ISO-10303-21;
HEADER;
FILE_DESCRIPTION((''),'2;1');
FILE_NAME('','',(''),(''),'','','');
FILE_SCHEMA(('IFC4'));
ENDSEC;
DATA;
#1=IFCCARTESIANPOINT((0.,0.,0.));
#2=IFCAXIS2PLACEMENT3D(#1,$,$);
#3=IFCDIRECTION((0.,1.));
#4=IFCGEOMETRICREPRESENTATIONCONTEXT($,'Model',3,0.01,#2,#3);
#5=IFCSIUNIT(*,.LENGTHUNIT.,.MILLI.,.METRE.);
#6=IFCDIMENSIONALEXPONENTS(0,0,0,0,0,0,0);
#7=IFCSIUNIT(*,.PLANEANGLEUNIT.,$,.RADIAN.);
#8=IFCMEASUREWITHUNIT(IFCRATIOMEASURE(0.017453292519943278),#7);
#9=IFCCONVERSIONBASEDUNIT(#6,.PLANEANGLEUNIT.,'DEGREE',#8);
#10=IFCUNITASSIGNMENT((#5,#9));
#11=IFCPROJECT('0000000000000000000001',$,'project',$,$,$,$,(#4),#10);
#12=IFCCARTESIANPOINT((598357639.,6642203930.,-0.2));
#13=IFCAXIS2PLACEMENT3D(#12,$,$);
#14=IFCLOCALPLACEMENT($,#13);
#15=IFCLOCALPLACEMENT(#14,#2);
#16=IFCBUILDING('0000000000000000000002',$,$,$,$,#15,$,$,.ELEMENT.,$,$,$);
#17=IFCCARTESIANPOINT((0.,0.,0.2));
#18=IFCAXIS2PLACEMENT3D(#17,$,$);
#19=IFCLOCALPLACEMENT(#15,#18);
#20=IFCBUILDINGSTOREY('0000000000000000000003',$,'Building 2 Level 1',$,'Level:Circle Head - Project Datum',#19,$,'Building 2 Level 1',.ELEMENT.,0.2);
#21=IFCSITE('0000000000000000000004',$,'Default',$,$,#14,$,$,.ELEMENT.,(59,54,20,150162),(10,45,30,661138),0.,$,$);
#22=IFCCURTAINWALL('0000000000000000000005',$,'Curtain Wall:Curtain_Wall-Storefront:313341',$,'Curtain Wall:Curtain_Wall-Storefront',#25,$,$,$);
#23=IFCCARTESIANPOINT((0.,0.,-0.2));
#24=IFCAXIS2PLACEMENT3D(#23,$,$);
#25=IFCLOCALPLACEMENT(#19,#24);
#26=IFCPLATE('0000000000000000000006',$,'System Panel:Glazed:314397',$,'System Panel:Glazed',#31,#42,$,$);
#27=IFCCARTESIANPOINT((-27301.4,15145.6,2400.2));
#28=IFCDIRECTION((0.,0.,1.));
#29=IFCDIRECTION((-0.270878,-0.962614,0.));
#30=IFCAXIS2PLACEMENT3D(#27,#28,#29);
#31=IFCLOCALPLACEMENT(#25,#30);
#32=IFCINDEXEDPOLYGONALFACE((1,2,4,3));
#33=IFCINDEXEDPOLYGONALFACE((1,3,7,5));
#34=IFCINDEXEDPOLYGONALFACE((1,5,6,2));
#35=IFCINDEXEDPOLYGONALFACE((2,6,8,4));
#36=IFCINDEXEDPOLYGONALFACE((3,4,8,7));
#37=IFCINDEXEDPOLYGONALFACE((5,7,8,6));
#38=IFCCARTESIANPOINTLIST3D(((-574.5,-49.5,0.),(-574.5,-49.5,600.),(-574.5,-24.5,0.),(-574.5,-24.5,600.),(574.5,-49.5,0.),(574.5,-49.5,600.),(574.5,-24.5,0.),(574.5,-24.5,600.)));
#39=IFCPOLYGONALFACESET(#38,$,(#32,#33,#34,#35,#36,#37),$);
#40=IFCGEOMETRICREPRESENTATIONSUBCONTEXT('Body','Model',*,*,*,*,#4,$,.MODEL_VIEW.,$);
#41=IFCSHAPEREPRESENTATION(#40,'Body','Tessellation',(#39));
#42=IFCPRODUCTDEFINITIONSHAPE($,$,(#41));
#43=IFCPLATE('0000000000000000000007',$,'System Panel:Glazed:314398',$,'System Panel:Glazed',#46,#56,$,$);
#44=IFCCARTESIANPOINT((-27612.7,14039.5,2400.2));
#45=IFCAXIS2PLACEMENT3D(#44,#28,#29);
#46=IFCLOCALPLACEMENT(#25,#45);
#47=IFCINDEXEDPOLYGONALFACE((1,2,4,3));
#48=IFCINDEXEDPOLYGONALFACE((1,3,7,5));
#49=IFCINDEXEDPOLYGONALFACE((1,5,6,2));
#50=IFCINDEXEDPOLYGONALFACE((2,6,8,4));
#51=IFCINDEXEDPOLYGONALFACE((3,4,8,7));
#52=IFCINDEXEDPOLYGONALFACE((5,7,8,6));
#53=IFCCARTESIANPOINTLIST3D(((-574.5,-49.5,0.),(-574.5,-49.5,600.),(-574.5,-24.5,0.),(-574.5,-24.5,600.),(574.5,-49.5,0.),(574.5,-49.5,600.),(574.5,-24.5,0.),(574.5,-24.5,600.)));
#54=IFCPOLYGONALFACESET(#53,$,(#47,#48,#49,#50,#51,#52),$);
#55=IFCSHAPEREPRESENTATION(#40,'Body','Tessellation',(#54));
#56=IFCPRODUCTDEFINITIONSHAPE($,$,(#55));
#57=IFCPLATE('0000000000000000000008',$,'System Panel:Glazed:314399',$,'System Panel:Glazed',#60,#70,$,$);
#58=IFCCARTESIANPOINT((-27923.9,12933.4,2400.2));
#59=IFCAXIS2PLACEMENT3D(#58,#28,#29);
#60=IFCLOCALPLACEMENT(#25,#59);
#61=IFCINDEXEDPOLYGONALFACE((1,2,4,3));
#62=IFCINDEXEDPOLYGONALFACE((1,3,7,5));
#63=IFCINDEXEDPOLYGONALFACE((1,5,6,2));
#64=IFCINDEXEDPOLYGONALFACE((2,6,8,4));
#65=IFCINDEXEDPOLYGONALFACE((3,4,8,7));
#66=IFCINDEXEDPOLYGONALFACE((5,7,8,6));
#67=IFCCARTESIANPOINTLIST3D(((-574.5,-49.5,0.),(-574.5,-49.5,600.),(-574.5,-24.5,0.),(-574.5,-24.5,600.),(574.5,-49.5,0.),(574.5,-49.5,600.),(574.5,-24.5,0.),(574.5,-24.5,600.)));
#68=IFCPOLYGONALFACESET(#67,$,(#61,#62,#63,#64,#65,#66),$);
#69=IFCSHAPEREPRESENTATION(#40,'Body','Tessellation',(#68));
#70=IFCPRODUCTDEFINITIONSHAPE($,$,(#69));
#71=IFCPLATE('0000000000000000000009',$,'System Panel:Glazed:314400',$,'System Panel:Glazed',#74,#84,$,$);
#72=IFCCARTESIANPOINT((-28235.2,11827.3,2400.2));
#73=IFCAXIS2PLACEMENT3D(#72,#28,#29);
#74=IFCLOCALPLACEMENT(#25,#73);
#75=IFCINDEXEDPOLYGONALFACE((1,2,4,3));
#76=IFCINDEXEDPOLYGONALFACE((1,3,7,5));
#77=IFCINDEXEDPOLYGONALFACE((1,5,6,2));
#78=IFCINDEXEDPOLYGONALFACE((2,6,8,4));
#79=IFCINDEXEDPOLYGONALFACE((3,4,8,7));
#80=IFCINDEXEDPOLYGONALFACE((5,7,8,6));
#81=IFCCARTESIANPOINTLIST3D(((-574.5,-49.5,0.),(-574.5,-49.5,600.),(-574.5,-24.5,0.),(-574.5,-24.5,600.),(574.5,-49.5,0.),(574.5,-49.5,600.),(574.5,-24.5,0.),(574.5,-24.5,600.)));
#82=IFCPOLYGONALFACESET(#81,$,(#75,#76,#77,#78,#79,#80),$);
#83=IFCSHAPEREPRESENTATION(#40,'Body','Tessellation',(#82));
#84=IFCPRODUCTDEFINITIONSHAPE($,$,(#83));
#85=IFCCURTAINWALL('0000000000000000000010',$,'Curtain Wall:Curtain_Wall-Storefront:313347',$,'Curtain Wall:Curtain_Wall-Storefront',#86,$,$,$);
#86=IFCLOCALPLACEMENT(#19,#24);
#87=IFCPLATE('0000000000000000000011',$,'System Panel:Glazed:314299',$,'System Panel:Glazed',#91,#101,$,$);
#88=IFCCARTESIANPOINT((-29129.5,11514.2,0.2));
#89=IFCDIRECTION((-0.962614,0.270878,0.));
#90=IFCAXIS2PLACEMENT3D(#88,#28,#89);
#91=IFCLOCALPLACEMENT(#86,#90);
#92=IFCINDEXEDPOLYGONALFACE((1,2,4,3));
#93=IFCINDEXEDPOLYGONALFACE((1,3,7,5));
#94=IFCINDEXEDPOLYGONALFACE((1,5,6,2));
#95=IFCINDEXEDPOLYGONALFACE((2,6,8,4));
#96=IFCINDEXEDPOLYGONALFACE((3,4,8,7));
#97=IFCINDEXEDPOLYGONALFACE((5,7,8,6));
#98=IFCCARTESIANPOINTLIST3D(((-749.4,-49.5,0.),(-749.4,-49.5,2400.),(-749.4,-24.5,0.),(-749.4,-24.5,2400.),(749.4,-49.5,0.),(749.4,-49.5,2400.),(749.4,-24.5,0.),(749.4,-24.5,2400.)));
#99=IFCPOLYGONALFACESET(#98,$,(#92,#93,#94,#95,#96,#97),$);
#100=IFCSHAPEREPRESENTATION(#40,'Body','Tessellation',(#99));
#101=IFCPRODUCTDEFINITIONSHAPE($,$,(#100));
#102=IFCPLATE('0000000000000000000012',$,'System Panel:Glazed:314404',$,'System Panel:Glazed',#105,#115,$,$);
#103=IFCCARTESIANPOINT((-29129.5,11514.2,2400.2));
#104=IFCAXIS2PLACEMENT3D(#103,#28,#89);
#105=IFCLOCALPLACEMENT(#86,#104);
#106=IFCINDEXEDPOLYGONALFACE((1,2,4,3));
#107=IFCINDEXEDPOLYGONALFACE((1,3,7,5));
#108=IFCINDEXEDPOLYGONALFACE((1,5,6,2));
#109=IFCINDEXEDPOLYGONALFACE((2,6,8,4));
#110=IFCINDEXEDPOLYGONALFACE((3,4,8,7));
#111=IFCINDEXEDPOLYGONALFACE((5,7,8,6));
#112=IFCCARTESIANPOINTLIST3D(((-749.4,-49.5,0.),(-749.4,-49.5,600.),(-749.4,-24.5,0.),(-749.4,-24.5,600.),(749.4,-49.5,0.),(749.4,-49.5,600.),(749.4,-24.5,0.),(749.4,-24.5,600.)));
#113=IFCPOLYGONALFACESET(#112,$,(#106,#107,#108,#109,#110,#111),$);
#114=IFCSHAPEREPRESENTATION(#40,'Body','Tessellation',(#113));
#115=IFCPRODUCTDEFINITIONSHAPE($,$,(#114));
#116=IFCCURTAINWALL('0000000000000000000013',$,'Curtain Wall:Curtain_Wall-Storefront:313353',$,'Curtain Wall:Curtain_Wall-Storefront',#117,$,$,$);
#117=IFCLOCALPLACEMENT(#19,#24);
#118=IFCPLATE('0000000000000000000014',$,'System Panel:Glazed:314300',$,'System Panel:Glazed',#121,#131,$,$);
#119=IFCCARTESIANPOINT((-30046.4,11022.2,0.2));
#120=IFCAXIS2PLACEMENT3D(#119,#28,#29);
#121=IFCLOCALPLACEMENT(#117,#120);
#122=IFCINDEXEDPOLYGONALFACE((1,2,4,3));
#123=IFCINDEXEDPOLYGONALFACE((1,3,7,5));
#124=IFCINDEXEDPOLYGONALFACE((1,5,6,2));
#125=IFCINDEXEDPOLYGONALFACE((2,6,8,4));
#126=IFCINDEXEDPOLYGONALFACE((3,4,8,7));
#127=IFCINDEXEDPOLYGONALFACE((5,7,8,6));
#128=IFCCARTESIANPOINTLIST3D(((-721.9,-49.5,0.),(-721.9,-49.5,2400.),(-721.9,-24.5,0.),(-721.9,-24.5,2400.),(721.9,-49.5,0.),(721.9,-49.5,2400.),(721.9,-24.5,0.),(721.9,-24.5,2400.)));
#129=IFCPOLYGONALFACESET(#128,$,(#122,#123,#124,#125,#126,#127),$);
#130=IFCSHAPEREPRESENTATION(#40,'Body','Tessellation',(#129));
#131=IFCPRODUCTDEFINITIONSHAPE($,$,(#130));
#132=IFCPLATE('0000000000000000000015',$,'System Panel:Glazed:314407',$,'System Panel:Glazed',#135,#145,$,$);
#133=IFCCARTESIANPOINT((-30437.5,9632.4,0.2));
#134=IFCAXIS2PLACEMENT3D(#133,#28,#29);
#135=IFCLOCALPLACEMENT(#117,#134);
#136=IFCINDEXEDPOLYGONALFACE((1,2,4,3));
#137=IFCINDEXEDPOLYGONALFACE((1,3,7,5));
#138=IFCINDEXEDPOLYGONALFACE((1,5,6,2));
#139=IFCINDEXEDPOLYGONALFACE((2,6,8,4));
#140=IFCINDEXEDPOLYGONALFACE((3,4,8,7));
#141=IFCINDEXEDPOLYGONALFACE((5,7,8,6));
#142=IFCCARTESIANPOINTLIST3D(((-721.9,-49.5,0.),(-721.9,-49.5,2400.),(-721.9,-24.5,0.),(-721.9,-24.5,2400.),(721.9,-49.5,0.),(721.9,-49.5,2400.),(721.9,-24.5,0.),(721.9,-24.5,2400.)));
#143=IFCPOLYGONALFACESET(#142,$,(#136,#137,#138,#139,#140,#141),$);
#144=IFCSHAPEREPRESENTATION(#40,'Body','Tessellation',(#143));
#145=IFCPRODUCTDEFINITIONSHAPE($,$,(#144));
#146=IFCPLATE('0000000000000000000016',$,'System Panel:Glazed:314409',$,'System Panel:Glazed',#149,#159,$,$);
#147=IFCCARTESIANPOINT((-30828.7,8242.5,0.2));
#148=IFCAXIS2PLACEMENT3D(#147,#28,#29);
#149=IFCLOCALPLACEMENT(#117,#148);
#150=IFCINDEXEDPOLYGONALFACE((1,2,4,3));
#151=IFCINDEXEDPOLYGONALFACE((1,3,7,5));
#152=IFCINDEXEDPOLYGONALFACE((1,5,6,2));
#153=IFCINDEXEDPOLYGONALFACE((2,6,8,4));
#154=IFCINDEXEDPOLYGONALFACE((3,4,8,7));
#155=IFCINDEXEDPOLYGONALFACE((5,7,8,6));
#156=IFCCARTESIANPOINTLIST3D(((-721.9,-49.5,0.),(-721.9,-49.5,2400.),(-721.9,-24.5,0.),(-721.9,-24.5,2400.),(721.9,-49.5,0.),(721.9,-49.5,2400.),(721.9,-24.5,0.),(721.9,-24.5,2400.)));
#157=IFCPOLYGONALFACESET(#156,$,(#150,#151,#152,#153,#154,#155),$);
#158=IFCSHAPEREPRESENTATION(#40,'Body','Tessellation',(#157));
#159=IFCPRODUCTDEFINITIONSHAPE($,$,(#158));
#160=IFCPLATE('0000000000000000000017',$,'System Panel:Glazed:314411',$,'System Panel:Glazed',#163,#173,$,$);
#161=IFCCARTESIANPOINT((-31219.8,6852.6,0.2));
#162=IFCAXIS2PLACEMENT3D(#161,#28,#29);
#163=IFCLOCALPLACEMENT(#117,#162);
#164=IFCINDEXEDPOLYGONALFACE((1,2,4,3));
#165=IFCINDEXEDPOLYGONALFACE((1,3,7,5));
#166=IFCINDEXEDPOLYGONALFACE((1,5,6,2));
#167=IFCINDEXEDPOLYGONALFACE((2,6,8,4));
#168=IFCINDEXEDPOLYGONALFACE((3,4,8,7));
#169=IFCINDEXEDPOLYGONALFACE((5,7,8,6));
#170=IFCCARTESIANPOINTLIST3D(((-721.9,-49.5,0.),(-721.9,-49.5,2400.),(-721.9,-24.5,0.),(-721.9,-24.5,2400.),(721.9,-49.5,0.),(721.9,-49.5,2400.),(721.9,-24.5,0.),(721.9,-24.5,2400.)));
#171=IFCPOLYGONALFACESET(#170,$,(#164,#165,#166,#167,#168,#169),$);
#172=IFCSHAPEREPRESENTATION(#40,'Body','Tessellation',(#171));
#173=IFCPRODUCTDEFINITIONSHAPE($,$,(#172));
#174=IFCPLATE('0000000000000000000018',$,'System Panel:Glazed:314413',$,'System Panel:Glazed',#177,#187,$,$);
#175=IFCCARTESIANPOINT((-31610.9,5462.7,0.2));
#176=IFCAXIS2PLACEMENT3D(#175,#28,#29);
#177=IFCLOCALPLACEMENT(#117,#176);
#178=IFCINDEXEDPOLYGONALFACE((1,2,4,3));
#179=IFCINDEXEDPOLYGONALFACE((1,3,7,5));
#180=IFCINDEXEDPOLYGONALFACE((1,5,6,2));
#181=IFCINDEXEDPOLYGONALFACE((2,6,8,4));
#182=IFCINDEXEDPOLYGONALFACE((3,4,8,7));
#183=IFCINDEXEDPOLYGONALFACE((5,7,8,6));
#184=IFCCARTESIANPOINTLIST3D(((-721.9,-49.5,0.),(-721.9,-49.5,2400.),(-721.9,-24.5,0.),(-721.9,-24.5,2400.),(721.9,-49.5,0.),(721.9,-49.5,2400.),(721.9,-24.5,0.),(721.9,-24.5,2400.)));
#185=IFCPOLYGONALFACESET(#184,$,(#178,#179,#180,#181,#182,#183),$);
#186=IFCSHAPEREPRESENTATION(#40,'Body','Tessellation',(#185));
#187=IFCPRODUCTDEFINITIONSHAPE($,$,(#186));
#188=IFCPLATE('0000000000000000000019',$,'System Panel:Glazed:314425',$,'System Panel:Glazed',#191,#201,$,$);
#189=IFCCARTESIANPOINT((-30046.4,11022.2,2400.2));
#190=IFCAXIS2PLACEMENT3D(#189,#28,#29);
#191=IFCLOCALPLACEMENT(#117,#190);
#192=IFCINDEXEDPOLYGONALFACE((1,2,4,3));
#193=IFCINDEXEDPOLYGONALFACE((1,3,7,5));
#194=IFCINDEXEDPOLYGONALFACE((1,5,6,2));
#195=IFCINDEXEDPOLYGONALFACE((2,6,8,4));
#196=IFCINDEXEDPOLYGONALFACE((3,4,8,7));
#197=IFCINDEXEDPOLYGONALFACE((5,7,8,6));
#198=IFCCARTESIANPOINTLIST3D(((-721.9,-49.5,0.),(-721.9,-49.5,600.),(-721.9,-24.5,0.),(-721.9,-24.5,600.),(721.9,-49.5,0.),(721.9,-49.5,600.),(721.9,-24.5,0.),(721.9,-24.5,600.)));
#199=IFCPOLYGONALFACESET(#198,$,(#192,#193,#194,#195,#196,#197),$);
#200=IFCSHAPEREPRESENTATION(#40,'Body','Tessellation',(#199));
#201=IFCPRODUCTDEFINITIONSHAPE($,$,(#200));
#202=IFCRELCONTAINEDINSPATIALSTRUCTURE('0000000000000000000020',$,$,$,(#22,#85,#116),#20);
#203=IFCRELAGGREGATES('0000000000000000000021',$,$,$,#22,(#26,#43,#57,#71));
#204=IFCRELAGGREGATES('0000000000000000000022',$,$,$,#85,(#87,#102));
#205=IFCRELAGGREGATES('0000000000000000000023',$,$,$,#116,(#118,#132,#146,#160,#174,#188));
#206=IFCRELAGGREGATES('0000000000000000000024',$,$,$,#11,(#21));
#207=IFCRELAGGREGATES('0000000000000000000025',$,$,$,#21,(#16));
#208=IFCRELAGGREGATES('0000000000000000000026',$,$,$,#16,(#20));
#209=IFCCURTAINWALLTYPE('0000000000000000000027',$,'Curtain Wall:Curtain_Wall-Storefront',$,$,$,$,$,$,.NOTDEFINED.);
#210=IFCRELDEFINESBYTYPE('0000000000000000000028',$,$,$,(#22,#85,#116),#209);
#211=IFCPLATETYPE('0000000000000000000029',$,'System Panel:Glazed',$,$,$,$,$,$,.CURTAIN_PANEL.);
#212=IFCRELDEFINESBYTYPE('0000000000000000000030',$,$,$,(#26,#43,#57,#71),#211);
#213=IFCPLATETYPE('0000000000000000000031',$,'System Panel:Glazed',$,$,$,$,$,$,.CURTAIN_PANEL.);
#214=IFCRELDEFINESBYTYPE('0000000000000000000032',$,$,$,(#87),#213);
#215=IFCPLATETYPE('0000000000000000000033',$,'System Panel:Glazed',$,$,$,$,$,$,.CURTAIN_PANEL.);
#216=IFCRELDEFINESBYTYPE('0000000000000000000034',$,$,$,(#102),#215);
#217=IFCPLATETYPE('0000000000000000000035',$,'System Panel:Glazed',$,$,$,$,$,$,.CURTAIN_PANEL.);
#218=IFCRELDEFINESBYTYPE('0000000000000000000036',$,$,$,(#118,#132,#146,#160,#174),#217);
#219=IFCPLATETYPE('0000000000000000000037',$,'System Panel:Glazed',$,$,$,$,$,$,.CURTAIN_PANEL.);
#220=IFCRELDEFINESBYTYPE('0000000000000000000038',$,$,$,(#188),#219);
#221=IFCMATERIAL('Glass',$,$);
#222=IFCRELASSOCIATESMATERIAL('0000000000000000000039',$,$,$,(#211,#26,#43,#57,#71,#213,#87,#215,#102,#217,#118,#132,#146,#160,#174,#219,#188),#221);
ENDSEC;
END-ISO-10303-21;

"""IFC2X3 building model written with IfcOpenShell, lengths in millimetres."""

from ifc_helpers import new_model, entity, si_unit, converted_unit, direction, frame, frame_2d, origin, place, context, subcontext, project, spatial, rectangle, extrude, source, transform, mapped, material, type_object, type_shapes, element, aggregate, save


model = new_model("IFC2X3")

# Units and contexts
model_context = context("Model", 3, precision=0.01, world=origin(), true_north=direction((0.0, 1.0)))
body_context = subcontext(model_context, "Body", "Model", "MODEL_VIEW")
ifc_project = project(units=[si_unit("LENGTHUNIT", "METRE", prefix="MILLI"), converted_unit("PLANEANGLEUNIT", "DEGREE", entity("IfcRatioMeasure", 0.017453292519943278), si_unit("PLANEANGLEUNIT", "RADIAN"), dimensions=[0, 0, 0, 0, 0, 0, 0])], contexts=[model_context])

# Site, building, storey
site_placement = place(None, frame((598357639.0, 6642203930.0, -0.2)))
site = spatial("IfcSite", under=ifc_project, at=site_placement, Name="Default", CompositionType="ELEMENT", RefLatitude=(59, 54, 20, 150162), RefLongitude=(10, 45, 30, 661138), RefElevation=0.0)
building_placement = place(site_placement, origin())
building = spatial("IfcBuilding", under=site, at=building_placement, CompositionType="ELEMENT")
storey_placement = place(building_placement, frame((0.0, 0.0, 0.2)))
storey = spatial("IfcBuildingStorey", under=building, at=storey_placement, Name="Building 2 Level 1", ObjectType="Level:Circle Head - Project Datum", LongName="Building 2 Level 1", CompositionType="ELEMENT", Elevation=0.2)

# Curtain walls, plates
curtain_wall_type = type_object("IfcCurtainWallType", Name="Curtain Wall:Curtain_Wall-Storefront", PredefinedType="NOTDEFINED")
ifc_material = material(Name="Glass")
curtain_wall_1_placement = place(storey_placement, frame((0.0, 0.0, -0.2)))
curtain_wall_1 = element("IfcCurtainWall", 1, at=curtain_wall_1_placement, inside=storey, type_object=curtain_wall_type, Name="Curtain Wall:Curtain_Wall-Storefront:313341", ObjectType="Curtain Wall:Curtain_Wall-Storefront")
plate_type_1 = type_object("IfcPlateType", Name="System Panel:Glazed", PredefinedType="CURTAIN_PANEL", material=ifc_material)
shared_shape_1 = source(origin(), body_context, "Body", "SweptSolid", [
    extrude(rectangle(XDim=25.0, YDim=1149.1, at=frame_2d((0.0, 0.0), x_axis=(1.0, 0.0))), frame((0.0, -37.0, 0.0), z_axis=(0.0, 0.0, 1.0), x_axis=(0.0, 1.0, 0.0)), (0.0, 0.0, 1.0), 600.0),
])
type_shapes(plate_type_1, [shared_shape_1])
plate_1_placement = place(curtain_wall_1_placement, frame((-27301.4, 15145.6, 2400.2), z_axis=(0.0, 0.0, 1.0), x_axis=(-0.270878, -0.962614, 0.0)))
plate_1 = element("IfcPlate", 2, at=plate_1_placement, type_object=plate_type_1, material=ifc_material, Name="System Panel:Glazed:314397", ObjectType="System Panel:Glazed", context=body_context, shape_type="MappedRepresentation", body=[
    mapped(shared_shape_1, transform((0.0, 0.0, 0.0), scale=1.0)),
])
plate_2_placement = place(curtain_wall_1_placement, frame((-27612.7, 14039.5, 2400.2), z_axis=(0.0, 0.0, 1.0), x_axis=(-0.270878, -0.962614, 0.0)))
plate_2 = element("IfcPlate", 3, at=plate_2_placement, type_object=plate_type_1, material=ifc_material, Name="System Panel:Glazed:314398", ObjectType="System Panel:Glazed", context=body_context, shape_type="MappedRepresentation", body=[
    mapped(shared_shape_1, transform((0.0, 0.0, 0.0), scale=1.0)),
])
plate_3_placement = place(curtain_wall_1_placement, frame((-27923.9, 12933.4, 2400.2), z_axis=(0.0, 0.0, 1.0), x_axis=(-0.270878, -0.962614, 0.0)))
plate_3 = element("IfcPlate", 4, at=plate_3_placement, type_object=plate_type_1, material=ifc_material, Name="System Panel:Glazed:314399", ObjectType="System Panel:Glazed", context=body_context, shape_type="MappedRepresentation", body=[
    mapped(shared_shape_1, transform((0.0, 0.0, 0.0), scale=1.0)),
])
plate_4_placement = place(curtain_wall_1_placement, frame((-28235.2, 11827.3, 2400.2), z_axis=(0.0, 0.0, 1.0), x_axis=(-0.270878, -0.962614, 0.0)))
plate_4 = element("IfcPlate", 5, at=plate_4_placement, type_object=plate_type_1, material=ifc_material, Name="System Panel:Glazed:314400", ObjectType="System Panel:Glazed", context=body_context, shape_type="MappedRepresentation", body=[
    mapped(shared_shape_1, transform((0.0, 0.0, 0.0), scale=1.0)),
])
aggregate(curtain_wall_1, [plate_1, plate_2, plate_3, plate_4])
curtain_wall_2_placement = place(storey_placement, frame((0.0, 0.0, -0.2)))
curtain_wall_2 = element("IfcCurtainWall", 6, at=curtain_wall_2_placement, inside=storey, type_object=curtain_wall_type, Name="Curtain Wall:Curtain_Wall-Storefront:313347", ObjectType="Curtain Wall:Curtain_Wall-Storefront")
plate_type_2 = type_object("IfcPlateType", Name="System Panel:Glazed", PredefinedType="CURTAIN_PANEL", material=ifc_material)
shared_shape_2 = source(origin(), body_context, "Body", "SweptSolid", [
    extrude(rectangle(XDim=25.0, YDim=1498.7, at=frame_2d((0.0, 0.0), x_axis=(1.0, 0.0))), frame((0.0, -37.0, 0.0), z_axis=(0.0, 0.0, 1.0), x_axis=(0.0, 1.0, 0.0)), (0.0, 0.0, 1.0), 2400.0),
])
type_shapes(plate_type_2, [shared_shape_2])
plate_5_placement = place(curtain_wall_2_placement, frame((-29129.5, 11514.2, 0.2), z_axis=(0.0, 0.0, 1.0), x_axis=(-0.962614, 0.270878, 0.0)))
plate_5 = element("IfcPlate", 7, at=plate_5_placement, type_object=plate_type_2, material=ifc_material, Name="System Panel:Glazed:314299", ObjectType="System Panel:Glazed", context=body_context, shape_type="MappedRepresentation", body=[
    mapped(shared_shape_2, transform((0.0, 0.0, 0.0), scale=1.0)),
])
plate_type_3 = type_object("IfcPlateType", Name="System Panel:Glazed", PredefinedType="CURTAIN_PANEL", material=ifc_material)
shared_shape_3 = source(origin(), body_context, "Body", "SweptSolid", [
    extrude(rectangle(XDim=25.0, YDim=1498.7, at=frame_2d((0.0, 0.0), x_axis=(1.0, 0.0))), frame((0.0, -37.0, 0.0), z_axis=(0.0, 0.0, 1.0), x_axis=(0.0, 1.0, 0.0)), (0.0, 0.0, 1.0), 600.0),
])
type_shapes(plate_type_3, [shared_shape_3])
plate_6_placement = place(curtain_wall_2_placement, frame((-29129.5, 11514.2, 2400.2), z_axis=(0.0, 0.0, 1.0), x_axis=(-0.962614, 0.270878, 0.0)))
plate_6 = element("IfcPlate", 8, at=plate_6_placement, type_object=plate_type_3, material=ifc_material, Name="System Panel:Glazed:314404", ObjectType="System Panel:Glazed", context=body_context, shape_type="MappedRepresentation", body=[
    mapped(shared_shape_3, transform((0.0, 0.0, 0.0), scale=1.0)),
])
aggregate(curtain_wall_2, [plate_5, plate_6])
curtain_wall_3_placement = place(storey_placement, frame((0.0, 0.0, -0.2)))
curtain_wall_3 = element("IfcCurtainWall", 9, at=curtain_wall_3_placement, inside=storey, type_object=curtain_wall_type, Name="Curtain Wall:Curtain_Wall-Storefront:313353", ObjectType="Curtain Wall:Curtain_Wall-Storefront")
plate_type_4 = type_object("IfcPlateType", Name="System Panel:Glazed", PredefinedType="CURTAIN_PANEL", material=ifc_material)
shared_shape_4 = source(origin(), body_context, "Body", "SweptSolid", [
    extrude(rectangle(XDim=25.0, YDim=1443.9, at=frame_2d((0.0, 0.0), x_axis=(1.0, 0.0))), frame((0.0, -37.0, 0.0), z_axis=(0.0, 0.0, 1.0), x_axis=(0.0, 1.0, 0.0)), (0.0, 0.0, 1.0), 2400.0),
])
type_shapes(plate_type_4, [shared_shape_4])
plate_7_placement = place(curtain_wall_3_placement, frame((-30046.4, 11022.2, 0.2), z_axis=(0.0, 0.0, 1.0), x_axis=(-0.270878, -0.962614, 0.0)))
plate_7 = element("IfcPlate", 10, at=plate_7_placement, type_object=plate_type_4, material=ifc_material, Name="System Panel:Glazed:314300", ObjectType="System Panel:Glazed", context=body_context, shape_type="MappedRepresentation", body=[
    mapped(shared_shape_4, transform((0.0, 0.0, 0.0), scale=1.0)),
])
plate_8_placement = place(curtain_wall_3_placement, frame((-30437.5, 9632.4, 0.2), z_axis=(0.0, 0.0, 1.0), x_axis=(-0.270878, -0.962614, 0.0)))
plate_8 = element("IfcPlate", 11, at=plate_8_placement, type_object=plate_type_4, material=ifc_material, Name="System Panel:Glazed:314407", ObjectType="System Panel:Glazed", context=body_context, shape_type="MappedRepresentation", body=[
    mapped(shared_shape_4, transform((0.0, 0.0, 0.0), scale=1.0)),
])
plate_9_placement = place(curtain_wall_3_placement, frame((-30828.7, 8242.5, 0.2), z_axis=(0.0, 0.0, 1.0), x_axis=(-0.270878, -0.962614, 0.0)))
plate_9 = element("IfcPlate", 12, at=plate_9_placement, type_object=plate_type_4, material=ifc_material, Name="System Panel:Glazed:314409", ObjectType="System Panel:Glazed", context=body_context, shape_type="MappedRepresentation", body=[
    mapped(shared_shape_4, transform((0.0, 0.0, 0.0), scale=1.0)),
])
plate_10_placement = place(curtain_wall_3_placement, frame((-31219.8, 6852.6, 0.2), z_axis=(0.0, 0.0, 1.0), x_axis=(-0.270878, -0.962614, 0.0)))
plate_10 = element("IfcPlate", 13, at=plate_10_placement, type_object=plate_type_4, material=ifc_material, Name="System Panel:Glazed:314411", ObjectType="System Panel:Glazed", context=body_context, shape_type="MappedRepresentation", body=[
    mapped(shared_shape_4, transform((0.0, 0.0, 0.0), scale=1.0)),
])
plate_11_placement = place(curtain_wall_3_placement, frame((-31610.9, 5462.7, 0.2), z_axis=(0.0, 0.0, 1.0), x_axis=(-0.270878, -0.962614, 0.0)))
plate_11 = element("IfcPlate", 14, at=plate_11_placement, type_object=plate_type_4, material=ifc_material, Name="System Panel:Glazed:314413", ObjectType="System Panel:Glazed", context=body_context, shape_type="MappedRepresentation", body=[
    mapped(shared_shape_4, transform((0.0, 0.0, 0.0), scale=1.0)),
])
plate_type_5 = type_object("IfcPlateType", Name="System Panel:Glazed", PredefinedType="CURTAIN_PANEL", material=ifc_material)
shared_shape_5 = source(origin(), body_context, "Body", "SweptSolid", [
    extrude(rectangle(XDim=25.0, YDim=1443.9, at=frame_2d((0.0, 0.0), x_axis=(1.0, 0.0))), frame((0.0, -37.0, 0.0), z_axis=(0.0, 0.0, 1.0), x_axis=(0.0, 1.0, 0.0)), (0.0, 0.0, 1.0), 600.0),
])
type_shapes(plate_type_5, [shared_shape_5])
plate_12_placement = place(curtain_wall_3_placement, frame((-30046.4, 11022.2, 2400.2), z_axis=(0.0, 0.0, 1.0), x_axis=(-0.270878, -0.962614, 0.0)))
plate_12 = element("IfcPlate", 15, at=plate_12_placement, type_object=plate_type_5, material=ifc_material, Name="System Panel:Glazed:314425", ObjectType="System Panel:Glazed", context=body_context, shape_type="MappedRepresentation", body=[
    mapped(shared_shape_5, transform((0.0, 0.0, 0.0), scale=1.0)),
])
aggregate(curtain_wall_3, [plate_7, plate_8, plate_9, plate_10, plate_11, plate_12])

save(model, "model.ifc")
